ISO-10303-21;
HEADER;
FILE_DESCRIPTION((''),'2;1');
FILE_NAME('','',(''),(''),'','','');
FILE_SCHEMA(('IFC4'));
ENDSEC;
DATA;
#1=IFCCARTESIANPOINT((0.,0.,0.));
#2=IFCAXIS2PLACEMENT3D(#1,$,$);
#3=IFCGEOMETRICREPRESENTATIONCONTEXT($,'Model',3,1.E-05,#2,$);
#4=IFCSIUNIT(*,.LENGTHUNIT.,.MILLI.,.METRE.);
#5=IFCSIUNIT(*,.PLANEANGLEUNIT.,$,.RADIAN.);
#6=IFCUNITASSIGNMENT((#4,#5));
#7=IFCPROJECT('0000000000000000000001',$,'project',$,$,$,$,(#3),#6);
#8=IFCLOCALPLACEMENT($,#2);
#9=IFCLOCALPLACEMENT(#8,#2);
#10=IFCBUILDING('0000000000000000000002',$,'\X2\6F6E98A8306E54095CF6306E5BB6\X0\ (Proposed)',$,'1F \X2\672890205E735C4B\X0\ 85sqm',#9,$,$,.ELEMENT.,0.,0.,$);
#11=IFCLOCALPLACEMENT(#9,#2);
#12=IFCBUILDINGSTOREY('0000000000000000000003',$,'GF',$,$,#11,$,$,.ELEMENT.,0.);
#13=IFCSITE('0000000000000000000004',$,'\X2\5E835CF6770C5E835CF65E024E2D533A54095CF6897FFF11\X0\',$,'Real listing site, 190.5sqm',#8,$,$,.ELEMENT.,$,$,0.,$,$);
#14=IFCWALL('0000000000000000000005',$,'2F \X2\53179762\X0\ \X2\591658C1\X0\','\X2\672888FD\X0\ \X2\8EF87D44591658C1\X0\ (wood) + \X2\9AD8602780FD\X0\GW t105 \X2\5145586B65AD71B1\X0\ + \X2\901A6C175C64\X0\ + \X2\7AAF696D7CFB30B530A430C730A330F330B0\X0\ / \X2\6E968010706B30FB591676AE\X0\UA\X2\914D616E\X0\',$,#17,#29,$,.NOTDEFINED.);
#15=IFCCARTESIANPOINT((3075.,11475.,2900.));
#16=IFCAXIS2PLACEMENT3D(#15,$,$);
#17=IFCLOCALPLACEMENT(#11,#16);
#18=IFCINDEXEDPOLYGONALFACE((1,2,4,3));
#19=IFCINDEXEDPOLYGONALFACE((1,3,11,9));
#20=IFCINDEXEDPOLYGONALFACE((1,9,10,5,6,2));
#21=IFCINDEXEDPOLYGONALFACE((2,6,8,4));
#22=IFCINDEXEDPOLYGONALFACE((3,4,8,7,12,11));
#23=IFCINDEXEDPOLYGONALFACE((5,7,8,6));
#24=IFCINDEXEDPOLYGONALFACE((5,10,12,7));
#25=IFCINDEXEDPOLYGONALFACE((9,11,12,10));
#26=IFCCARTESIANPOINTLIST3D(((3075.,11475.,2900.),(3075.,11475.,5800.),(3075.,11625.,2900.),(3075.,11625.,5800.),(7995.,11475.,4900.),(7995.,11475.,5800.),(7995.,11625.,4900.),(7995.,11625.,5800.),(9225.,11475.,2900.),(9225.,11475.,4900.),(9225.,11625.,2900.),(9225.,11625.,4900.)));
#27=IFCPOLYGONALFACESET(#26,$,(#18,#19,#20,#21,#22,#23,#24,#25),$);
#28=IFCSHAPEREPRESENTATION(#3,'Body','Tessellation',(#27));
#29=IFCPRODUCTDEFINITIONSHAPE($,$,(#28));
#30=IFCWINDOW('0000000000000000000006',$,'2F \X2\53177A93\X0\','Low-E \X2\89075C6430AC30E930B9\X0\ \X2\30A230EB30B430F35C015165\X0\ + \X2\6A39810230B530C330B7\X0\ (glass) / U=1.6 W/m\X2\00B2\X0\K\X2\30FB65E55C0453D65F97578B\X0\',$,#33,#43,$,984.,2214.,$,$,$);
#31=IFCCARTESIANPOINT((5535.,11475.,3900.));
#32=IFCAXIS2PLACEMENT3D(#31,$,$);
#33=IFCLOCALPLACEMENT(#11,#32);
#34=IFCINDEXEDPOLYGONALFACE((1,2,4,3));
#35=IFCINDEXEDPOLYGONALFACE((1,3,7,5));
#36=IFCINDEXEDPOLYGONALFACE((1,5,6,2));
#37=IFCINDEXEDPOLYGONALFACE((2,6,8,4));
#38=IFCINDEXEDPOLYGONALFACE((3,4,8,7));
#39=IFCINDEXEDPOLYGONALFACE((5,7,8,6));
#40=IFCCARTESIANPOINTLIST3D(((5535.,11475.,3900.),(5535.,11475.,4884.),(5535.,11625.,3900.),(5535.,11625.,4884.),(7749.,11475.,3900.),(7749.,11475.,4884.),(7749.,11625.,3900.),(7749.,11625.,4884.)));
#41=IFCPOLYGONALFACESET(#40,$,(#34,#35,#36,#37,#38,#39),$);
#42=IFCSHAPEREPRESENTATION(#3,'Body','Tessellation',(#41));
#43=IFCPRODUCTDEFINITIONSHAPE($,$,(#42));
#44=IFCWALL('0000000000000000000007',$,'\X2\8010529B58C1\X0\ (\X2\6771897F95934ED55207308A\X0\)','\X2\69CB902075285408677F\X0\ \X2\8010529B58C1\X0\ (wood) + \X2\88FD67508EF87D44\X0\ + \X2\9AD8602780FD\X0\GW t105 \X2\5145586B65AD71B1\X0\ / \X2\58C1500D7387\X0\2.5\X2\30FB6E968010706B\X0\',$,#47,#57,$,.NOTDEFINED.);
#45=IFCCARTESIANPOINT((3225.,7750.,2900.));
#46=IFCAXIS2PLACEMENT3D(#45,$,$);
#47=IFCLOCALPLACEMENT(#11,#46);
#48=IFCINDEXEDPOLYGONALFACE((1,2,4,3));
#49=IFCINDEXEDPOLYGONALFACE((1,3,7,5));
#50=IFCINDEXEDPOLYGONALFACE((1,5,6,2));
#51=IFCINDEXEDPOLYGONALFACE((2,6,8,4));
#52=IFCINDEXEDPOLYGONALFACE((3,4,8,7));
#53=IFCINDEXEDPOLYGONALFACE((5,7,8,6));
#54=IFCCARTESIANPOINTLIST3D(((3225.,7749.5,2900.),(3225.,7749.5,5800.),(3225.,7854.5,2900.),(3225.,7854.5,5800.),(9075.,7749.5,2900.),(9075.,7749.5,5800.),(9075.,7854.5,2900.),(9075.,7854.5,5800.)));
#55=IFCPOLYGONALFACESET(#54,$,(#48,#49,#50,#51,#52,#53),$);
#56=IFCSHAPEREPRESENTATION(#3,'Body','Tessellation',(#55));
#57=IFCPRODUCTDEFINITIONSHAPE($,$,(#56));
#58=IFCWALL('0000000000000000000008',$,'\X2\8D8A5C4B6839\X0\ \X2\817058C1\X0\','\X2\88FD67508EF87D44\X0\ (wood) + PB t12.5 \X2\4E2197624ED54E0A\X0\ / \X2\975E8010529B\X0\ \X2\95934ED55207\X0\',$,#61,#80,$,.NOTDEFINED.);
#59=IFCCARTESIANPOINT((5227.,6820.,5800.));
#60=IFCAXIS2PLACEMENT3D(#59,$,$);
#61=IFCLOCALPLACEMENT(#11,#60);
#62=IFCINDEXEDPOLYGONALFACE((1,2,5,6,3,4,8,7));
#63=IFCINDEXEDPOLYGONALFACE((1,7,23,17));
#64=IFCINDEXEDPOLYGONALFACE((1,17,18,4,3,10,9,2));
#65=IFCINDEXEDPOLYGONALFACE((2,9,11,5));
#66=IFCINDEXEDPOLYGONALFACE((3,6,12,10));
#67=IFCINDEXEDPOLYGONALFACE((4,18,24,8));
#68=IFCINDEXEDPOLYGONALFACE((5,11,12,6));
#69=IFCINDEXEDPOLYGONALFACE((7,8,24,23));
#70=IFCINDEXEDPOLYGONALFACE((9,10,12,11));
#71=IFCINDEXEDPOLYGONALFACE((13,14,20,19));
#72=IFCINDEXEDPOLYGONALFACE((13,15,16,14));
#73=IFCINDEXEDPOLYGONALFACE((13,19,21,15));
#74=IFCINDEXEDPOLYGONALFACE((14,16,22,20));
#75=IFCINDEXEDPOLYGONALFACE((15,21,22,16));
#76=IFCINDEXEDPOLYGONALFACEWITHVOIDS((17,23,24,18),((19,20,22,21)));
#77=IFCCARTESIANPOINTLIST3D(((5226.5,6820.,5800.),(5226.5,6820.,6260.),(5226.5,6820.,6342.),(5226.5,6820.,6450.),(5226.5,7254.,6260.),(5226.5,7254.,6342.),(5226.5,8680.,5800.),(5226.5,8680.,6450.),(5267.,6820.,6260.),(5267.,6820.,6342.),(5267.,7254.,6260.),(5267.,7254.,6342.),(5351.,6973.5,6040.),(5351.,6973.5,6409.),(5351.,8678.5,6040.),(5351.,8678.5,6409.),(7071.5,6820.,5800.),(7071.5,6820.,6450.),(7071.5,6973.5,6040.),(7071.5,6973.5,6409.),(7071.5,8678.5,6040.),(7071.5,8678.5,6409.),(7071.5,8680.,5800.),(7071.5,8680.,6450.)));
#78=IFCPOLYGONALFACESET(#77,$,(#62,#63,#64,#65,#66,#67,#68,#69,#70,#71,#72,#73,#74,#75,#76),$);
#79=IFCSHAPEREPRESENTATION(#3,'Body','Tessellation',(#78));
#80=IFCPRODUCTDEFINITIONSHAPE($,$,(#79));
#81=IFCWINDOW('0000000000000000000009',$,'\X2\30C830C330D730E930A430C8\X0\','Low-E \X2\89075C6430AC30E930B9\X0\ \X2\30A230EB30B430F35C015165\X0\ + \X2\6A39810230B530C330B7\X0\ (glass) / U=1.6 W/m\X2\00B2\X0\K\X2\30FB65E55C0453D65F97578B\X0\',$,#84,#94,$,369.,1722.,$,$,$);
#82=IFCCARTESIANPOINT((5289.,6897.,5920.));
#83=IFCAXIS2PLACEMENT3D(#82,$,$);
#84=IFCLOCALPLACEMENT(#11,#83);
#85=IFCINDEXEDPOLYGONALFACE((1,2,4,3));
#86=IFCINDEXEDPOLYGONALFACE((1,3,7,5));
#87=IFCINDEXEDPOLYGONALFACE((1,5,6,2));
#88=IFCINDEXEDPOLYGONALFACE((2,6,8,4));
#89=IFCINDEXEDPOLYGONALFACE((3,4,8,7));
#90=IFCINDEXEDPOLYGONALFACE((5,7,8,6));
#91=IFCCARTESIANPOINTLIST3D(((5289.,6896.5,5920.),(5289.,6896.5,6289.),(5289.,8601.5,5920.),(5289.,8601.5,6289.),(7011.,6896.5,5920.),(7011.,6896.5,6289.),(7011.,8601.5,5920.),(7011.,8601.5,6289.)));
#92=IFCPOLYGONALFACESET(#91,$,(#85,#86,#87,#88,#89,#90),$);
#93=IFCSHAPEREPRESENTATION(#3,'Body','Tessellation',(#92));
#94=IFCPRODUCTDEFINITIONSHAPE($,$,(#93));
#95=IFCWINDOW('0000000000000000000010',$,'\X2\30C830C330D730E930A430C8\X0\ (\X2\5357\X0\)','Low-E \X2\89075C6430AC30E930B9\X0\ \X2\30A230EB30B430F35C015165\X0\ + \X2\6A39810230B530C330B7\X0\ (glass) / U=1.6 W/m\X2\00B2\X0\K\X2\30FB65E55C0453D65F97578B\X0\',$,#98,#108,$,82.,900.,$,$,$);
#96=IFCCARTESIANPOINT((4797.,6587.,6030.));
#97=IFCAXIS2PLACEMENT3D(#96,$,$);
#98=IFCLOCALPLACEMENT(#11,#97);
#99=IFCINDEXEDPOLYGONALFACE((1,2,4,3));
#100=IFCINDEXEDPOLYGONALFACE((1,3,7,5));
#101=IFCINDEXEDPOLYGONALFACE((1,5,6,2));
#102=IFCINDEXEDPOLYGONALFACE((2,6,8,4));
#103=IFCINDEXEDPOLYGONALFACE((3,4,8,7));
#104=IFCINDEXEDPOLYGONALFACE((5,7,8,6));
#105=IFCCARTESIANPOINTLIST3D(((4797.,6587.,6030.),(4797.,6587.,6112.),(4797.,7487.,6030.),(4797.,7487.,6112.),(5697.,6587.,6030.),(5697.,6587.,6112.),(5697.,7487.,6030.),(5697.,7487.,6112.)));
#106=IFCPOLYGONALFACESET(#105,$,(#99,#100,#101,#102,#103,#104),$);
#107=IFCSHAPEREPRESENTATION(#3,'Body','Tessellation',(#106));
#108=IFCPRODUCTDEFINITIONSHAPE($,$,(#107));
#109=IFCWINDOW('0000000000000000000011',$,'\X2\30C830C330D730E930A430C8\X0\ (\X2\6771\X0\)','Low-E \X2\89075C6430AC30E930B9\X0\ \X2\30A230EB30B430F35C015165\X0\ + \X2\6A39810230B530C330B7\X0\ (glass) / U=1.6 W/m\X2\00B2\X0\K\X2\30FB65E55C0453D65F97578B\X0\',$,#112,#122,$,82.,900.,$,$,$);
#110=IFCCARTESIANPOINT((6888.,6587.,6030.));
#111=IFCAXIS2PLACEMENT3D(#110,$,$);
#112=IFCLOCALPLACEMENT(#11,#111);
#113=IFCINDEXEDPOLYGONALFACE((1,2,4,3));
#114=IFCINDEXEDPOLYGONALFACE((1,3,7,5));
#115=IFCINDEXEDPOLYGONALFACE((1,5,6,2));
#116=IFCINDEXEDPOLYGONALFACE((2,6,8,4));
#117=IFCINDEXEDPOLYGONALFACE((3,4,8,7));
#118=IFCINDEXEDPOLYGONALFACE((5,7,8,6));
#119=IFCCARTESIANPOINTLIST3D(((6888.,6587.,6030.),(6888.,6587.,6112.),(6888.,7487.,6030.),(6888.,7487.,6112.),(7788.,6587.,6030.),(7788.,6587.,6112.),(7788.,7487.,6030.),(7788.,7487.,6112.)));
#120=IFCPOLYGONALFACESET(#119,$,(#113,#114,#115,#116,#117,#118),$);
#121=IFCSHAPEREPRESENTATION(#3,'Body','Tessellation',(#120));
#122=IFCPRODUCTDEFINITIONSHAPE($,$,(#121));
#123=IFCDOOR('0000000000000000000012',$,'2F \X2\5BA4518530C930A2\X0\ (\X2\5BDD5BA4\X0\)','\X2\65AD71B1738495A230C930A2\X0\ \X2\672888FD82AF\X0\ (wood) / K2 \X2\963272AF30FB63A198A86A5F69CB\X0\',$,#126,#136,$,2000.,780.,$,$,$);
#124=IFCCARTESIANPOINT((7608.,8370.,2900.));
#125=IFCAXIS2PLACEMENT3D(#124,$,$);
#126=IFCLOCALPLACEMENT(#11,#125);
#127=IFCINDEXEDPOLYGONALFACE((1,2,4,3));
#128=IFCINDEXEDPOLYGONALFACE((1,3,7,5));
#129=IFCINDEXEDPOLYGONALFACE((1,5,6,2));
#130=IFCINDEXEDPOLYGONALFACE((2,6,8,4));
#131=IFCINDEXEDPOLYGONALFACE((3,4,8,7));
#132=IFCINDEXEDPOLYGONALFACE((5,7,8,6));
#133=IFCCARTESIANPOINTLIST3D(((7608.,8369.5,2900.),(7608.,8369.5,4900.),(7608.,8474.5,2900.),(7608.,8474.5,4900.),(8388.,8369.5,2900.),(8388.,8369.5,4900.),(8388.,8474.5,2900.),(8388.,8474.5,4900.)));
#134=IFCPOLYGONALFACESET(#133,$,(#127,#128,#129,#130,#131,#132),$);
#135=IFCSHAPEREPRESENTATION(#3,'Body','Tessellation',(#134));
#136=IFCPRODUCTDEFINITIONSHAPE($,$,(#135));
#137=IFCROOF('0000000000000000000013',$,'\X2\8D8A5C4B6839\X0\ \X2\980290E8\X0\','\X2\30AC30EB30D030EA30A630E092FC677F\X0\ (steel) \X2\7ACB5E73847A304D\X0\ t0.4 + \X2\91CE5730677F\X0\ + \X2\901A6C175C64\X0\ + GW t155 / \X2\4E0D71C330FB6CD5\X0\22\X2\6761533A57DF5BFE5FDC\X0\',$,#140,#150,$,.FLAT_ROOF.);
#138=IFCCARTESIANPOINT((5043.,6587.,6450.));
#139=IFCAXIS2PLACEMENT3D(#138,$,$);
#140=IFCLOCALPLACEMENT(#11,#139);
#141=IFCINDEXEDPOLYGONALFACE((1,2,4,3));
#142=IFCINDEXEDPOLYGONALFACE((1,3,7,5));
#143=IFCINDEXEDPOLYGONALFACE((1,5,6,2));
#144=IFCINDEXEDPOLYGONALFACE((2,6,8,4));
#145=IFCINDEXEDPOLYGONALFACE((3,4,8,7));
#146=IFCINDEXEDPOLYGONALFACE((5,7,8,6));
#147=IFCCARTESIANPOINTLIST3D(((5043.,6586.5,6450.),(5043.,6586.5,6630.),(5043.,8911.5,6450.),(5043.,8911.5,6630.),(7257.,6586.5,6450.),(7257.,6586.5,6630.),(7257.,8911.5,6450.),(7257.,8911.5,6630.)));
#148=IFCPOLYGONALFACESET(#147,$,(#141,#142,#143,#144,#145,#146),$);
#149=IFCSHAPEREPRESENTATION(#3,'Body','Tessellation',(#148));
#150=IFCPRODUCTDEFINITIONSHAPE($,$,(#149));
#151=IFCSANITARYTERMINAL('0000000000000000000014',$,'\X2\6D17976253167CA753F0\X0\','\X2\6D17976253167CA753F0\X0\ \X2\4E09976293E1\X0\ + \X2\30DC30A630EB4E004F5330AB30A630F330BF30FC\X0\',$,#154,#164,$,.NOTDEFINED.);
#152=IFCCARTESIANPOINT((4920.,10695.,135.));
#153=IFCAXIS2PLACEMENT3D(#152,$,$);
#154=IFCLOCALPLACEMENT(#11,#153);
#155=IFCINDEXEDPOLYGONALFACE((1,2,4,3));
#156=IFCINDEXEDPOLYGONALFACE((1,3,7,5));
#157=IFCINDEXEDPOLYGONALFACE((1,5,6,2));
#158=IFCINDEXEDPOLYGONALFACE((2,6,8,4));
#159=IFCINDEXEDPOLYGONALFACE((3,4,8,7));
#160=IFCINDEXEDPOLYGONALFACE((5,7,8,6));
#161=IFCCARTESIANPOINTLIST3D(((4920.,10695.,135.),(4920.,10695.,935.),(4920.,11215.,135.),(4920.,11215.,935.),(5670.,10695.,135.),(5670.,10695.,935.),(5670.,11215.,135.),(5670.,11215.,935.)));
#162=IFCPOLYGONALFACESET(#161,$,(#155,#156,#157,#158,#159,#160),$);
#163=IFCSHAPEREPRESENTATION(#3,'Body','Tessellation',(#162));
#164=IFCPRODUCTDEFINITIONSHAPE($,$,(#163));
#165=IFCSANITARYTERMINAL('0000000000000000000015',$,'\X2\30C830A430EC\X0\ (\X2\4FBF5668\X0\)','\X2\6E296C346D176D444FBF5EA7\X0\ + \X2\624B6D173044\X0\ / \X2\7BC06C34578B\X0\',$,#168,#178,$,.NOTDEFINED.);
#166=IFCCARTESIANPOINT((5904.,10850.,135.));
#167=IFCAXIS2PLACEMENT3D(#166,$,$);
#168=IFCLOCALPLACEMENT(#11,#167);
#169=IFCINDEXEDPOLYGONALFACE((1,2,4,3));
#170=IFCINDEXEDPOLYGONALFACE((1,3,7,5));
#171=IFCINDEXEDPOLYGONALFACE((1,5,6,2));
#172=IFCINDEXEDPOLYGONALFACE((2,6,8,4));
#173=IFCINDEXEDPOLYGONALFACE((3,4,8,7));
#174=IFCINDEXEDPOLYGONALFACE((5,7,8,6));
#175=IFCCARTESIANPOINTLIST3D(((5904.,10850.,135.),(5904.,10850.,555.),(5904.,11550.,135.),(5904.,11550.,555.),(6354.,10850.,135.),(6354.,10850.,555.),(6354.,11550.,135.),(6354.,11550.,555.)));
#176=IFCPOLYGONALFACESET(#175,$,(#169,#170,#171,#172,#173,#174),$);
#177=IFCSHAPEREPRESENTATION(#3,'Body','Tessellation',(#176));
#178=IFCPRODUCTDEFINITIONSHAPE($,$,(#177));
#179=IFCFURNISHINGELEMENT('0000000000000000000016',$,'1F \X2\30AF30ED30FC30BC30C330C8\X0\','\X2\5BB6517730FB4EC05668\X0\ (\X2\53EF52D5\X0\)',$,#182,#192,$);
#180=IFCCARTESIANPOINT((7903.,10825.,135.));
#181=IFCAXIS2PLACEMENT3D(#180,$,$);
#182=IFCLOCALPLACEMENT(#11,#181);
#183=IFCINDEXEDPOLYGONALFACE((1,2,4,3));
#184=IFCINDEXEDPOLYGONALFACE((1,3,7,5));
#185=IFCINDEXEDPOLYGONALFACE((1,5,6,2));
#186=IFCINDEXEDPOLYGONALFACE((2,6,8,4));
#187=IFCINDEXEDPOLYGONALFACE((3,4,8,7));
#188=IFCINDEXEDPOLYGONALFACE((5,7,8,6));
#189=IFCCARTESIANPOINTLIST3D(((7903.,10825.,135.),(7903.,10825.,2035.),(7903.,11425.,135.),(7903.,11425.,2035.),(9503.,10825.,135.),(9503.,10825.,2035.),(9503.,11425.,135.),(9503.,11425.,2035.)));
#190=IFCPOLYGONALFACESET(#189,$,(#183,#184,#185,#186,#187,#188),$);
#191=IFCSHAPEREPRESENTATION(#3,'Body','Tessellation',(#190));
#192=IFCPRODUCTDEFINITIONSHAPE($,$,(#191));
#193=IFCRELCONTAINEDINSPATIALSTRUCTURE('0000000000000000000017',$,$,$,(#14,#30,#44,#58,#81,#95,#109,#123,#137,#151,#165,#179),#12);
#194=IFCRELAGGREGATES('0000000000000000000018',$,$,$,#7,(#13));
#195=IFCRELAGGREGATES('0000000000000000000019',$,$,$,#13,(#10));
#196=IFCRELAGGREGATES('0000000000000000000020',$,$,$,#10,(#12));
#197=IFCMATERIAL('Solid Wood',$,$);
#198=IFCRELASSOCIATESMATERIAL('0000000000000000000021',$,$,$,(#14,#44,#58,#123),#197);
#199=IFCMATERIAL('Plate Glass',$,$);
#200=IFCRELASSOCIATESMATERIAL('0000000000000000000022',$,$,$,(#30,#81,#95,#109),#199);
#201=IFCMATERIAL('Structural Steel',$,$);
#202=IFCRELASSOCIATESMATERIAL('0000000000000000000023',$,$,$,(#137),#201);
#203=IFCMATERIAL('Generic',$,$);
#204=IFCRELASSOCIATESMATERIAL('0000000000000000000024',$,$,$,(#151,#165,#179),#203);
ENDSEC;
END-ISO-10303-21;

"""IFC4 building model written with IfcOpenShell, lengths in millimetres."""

from ifc_helpers import new_model, si_unit, frame, frame_2d, origin, place, context, project, spatial, rectangle, extrude, material, element, fill, save


model = new_model("IFC4")

# Units and contexts
model_context = context("Model", 3, precision=1e-05, world=origin())
ifc_project = project(units=[si_unit("LENGTHUNIT", "METRE", prefix="MILLI"), si_unit("PLANEANGLEUNIT", "RADIAN")], contexts=[model_context])

# Site, building, storey
site_placement = place(None, origin())
site = spatial("IfcSite", under=ifc_project, at=site_placement, Name="広島県広島市中区吉島西１", ObjectType="Real listing site, 190.5sqm", CompositionType="ELEMENT", RefElevation=0.0)
building_placement = place(site_placement, origin())
building = spatial("IfcBuilding", under=site, at=building_placement, Name="潮風の吉島の家 (Proposed)", ObjectType="1F 木造平屋 85sqm", CompositionType="ELEMENT", ElevationOfRefHeight=0.0, ElevationOfTerrain=0.0)
storey_placement = place(building_placement, origin())
storey = spatial("IfcBuildingStorey", under=building, at=storey_placement, Name="GF", CompositionType="ELEMENT", Elevation=0.0)

# Wall, opening, window
ifc_material_1 = material(Name="Solid Wood")
wall_1_placement = place(storey_placement, frame((3075.0, 11475.0, 2900.0)))
wall_1 = element("IfcWall", 1, at=wall_1_placement, inside=storey, material=ifc_material_1, Name="2F 北面 外壁", Description="木製 軸組外壁 (wood) + 高性能GW t105 充填断熱 + 通気層 + 窯業系サイディング / 準耐火・外皮UA配慮", PredefinedType="NOTDEFINED", context=model_context, shape_type="SweptSolid", body=[
    extrude(rectangle(XDim=6150.0, YDim=150.0, at=frame_2d((3075.0, 75.0))), frame((3075.0, 11475.0, 2900.0)), (0.0, 0.0, 1.0), 2900.0),
])
opening_1_placement = place(storey_placement, frame((5535.0, 11475.0, 3900.0)))
opening_1 = element("IfcOpeningElement", 2, at=opening_1_placement, cuts=wall_1, PredefinedType="NOTDEFINED", context=model_context, shape_type="SweptSolid", body=[
    extrude(rectangle(XDim=2214.0, YDim=150.0, at=frame_2d((1107.0, 75.0))), frame((5535.0, 11475.0, 3900.0)), (0.0, 0.0, 1.0), 984.0),
])
ifc_material_2 = material(Name="Plate Glass")
window_1_placement = place(storey_placement, frame((5535.0, 11475.0, 3900.0)))
window_1 = element("IfcWindow", 3, at=window_1_placement, inside=storey, material=ifc_material_2, Name="2F 北窓", Description="Low-E 複層ガラス アルゴン封入 + 樹脂サッシ (glass) / U=1.6 W/m²K・日射取得型", OverallHeight=984.0, OverallWidth=2214.0, context=model_context, shape_type="SweptSolid", body=[
    extrude(rectangle(XDim=2214.0, YDim=150.0, at=frame_2d((1107.0, 75.0))), frame((5535.0, 11475.0, 3900.0)), (0.0, 0.0, 1.0), 984.0),
])
fill(opening_1, window_1)

# Wall
wall_2_placement = place(storey_placement, frame((3225.0, 7750.0, 2900.0)))
element("IfcWall", 4, at=wall_2_placement, inside=storey, material=ifc_material_1, Name="耐力壁 (東西間仕切り)", Description="構造用合板 耐力壁 (wood) + 製材軸組 + 高性能GW t105 充填断熱 / 壁倍率2.5・準耐火", PredefinedType="NOTDEFINED", context=model_context, shape_type="SweptSolid", body=[
    extrude(rectangle(XDim=5850.0, YDim=105.0, at=frame_2d((2925.0, 52.0))), frame((3225.0, 7750.0, 2900.0)), (0.0, 0.0, 1.0), 2900.0),
])

# Wall, openings, windows
wall_3_placement = place(storey_placement, frame((5227.0, 6820.0, 5800.0)))
wall_3 = element("IfcWall", 5, at=wall_3_placement, inside=storey, material=ifc_material_1, Name="越屋根 腰壁", Description="製材軸組 (wood) + PB t12.5 両面仕上 / 非耐力 間仕切", PredefinedType="NOTDEFINED", context=model_context, shape_type="SweptSolid", body=[
    extrude(rectangle(XDim=1845.0, YDim=1860.0, at=frame_2d((922.0, 930.0))), frame((5227.0, 6820.0, 5800.0)), (0.0, 0.0, 1.0), 650.0),
])
opening_2_placement = place(storey_placement, frame((5289.0, 6897.0, 5920.0)))
opening_2 = element("IfcOpeningElement", 6, at=opening_2_placement, cuts=wall_3, PredefinedType="NOTDEFINED", context=model_context, shape_type="SweptSolid", body=[
    extrude(rectangle(XDim=1722.0, YDim=1705.0, at=frame_2d((861.0, 852.0))), frame((5289.0, 6897.0, 5920.0)), (0.0, 0.0, 1.0), 369.0),
])
opening_3_placement = place(storey_placement, frame((4797.0, 6587.0, 6030.0)))
opening_3 = element("IfcOpeningElement", 7, at=opening_3_placement, cuts=wall_3, PredefinedType="NOTDEFINED", context=model_context, shape_type="SweptSolid", body=[
    extrude(rectangle(XDim=900.0, YDim=900.0, at=frame_2d((450.0, 450.0))), frame((4797.0, 6587.0, 6030.0)), (0.0, 0.0, 1.0), 82.0),
])
opening_4_placement = place(storey_placement, frame((6888.0, 6587.0, 6030.0)))
opening_4 = element("IfcOpeningElement", 8, at=opening_4_placement, cuts=wall_3, PredefinedType="NOTDEFINED", context=model_context, shape_type="SweptSolid", body=[
    extrude(rectangle(XDim=900.0, YDim=900.0, at=frame_2d((450.0, 450.0))), frame((6888.0, 6587.0, 6030.0)), (0.0, 0.0, 1.0), 82.0),
])
window_2_placement = place(storey_placement, frame((5289.0, 6897.0, 5920.0)))
window_2 = element("IfcWindow", 9, at=window_2_placement, inside=storey, material=ifc_material_2, Name="トップライト", Description="Low-E 複層ガラス アルゴン封入 + 樹脂サッシ (glass) / U=1.6 W/m²K・日射取得型", OverallHeight=369.0, OverallWidth=1722.0, context=model_context, shape_type="SweptSolid", body=[
    extrude(rectangle(XDim=1722.0, YDim=1705.0, at=frame_2d((861.0, 852.0))), frame((5289.0, 6897.0, 5920.0)), (0.0, 0.0, 1.0), 369.0),
])
fill(opening_2, window_2)
window_3_placement = place(storey_placement, frame((4797.0, 6587.0, 6030.0)))
window_3 = element("IfcWindow", 10, at=window_3_placement, inside=storey, material=ifc_material_2, Name="トップライト (南)", Description="Low-E 複層ガラス アルゴン封入 + 樹脂サッシ (glass) / U=1.6 W/m²K・日射取得型", OverallHeight=82.0, OverallWidth=900.0, context=model_context, shape_type="SweptSolid", body=[
    extrude(rectangle(XDim=900.0, YDim=900.0, at=frame_2d((450.0, 450.0))), frame((4797.0, 6587.0, 6030.0)), (0.0, 0.0, 1.0), 82.0),
])
fill(opening_3, window_3)
window_4_placement = place(storey_placement, frame((6888.0, 6587.0, 6030.0)))
window_4 = element("IfcWindow", 11, at=window_4_placement, inside=storey, material=ifc_material_2, Name="トップライト (東)", Description="Low-E 複層ガラス アルゴン封入 + 樹脂サッシ (glass) / U=1.6 W/m²K・日射取得型", OverallHeight=82.0, OverallWidth=900.0, context=model_context, shape_type="SweptSolid", body=[
    extrude(rectangle(XDim=900.0, YDim=900.0, at=frame_2d((450.0, 450.0))), frame((6888.0, 6587.0, 6030.0)), (0.0, 0.0, 1.0), 82.0),
])
fill(opening_4, window_4)

# Door
door_placement = place(storey_placement, frame((7608.0, 8370.0, 2900.0)))
element("IfcDoor", 12, at=door_placement, inside=storey, material=ifc_material_1, Name="2F 室内ドア (寝室)", Description="断熱玄関ドア 木製芯 (wood) / K2 防犯・採風機構", OverallHeight=2000.0, OverallWidth=780.0, context=model_context, shape_type="SweptSolid", body=[
    extrude(rectangle(XDim=780.0, YDim=105.0, at=frame_2d((390.0, 52.0))), frame((7608.0, 8370.0, 2900.0)), (0.0, 0.0, 1.0), 2000.0),
])

# Roof
ifc_material_3 = material(Name="Structural Steel")
roof_placement = place(storey_placement, frame((5043.0, 6587.0, 6450.0)))
element("IfcRoof", 13, at=roof_placement, inside=storey, material=ifc_material_3, Name="越屋根 頂部", Description="ガルバリウム鋼板 (steel) 立平葺き t0.4 + 野地板 + 通気層 + GW t155 / 不燃・法22条区域対応", PredefinedType="FLAT_ROOF", context=model_context, shape_type="SweptSolid", body=[
    extrude(rectangle(XDim=2214.0, YDim=2325.0, at=frame_2d((1107.0, 1162.0))), frame((5043.0, 6587.0, 6450.0)), (0.0, 0.0, 1.0), 180.0),
])

# Sanitary terminals
ifc_material_4 = material(Name="Generic")
sanitary_terminal_1_placement = place(storey_placement, frame((4920.0, 10695.0, 135.0)))
element("IfcSanitaryTerminal", 14, at=sanitary_terminal_1_placement, inside=storey, material=ifc_material_4, Name="洗面化粧台", Description="洗面化粧台 三面鏡 + ボウル一体カウンター", PredefinedType="NOTDEFINED", context=model_context, shape_type="SweptSolid", body=[
    extrude(rectangle(XDim=750.0, YDim=520.0, at=frame_2d((375.0, 260.0))), frame((4920.0, 10695.0, 135.0)), (0.0, 0.0, 1.0), 800.0),
])
sanitary_terminal_2_placement = place(storey_placement, frame((5904.0, 10850.0, 135.0)))
element("IfcSanitaryTerminal", 15, at=sanitary_terminal_2_placement, inside=storey, material=ifc_material_4, Name="トイレ (便器)", Description="温水洗浄便座 + 手洗い / 節水型", PredefinedType="NOTDEFINED", context=model_context, shape_type="SweptSolid", body=[
    extrude(rectangle(XDim=450.0, YDim=700.0, at=frame_2d((225.0, 350.0))), frame((5904.0, 10850.0, 135.0)), (0.0, 0.0, 1.0), 420.0),
])

# Furnishing element
furnishing_1_placement = place(storey_placement, frame((7903.0, 10825.0, 135.0)))
element("IfcFurnishingElement", 16, at=furnishing_1_placement, inside=storey, material=ifc_material_4, Name="1F クローゼット", Description="家具・什器 (可動)", context=model_context, shape_type="SweptSolid", body=[
    extrude(rectangle(XDim=1600.0, YDim=600.0, at=frame_2d((800.0, 300.0))), frame((7903.0, 10825.0, 135.0)), (0.0, 0.0, 1.0), 1900.0),
])

save(model, "model.ifc")
